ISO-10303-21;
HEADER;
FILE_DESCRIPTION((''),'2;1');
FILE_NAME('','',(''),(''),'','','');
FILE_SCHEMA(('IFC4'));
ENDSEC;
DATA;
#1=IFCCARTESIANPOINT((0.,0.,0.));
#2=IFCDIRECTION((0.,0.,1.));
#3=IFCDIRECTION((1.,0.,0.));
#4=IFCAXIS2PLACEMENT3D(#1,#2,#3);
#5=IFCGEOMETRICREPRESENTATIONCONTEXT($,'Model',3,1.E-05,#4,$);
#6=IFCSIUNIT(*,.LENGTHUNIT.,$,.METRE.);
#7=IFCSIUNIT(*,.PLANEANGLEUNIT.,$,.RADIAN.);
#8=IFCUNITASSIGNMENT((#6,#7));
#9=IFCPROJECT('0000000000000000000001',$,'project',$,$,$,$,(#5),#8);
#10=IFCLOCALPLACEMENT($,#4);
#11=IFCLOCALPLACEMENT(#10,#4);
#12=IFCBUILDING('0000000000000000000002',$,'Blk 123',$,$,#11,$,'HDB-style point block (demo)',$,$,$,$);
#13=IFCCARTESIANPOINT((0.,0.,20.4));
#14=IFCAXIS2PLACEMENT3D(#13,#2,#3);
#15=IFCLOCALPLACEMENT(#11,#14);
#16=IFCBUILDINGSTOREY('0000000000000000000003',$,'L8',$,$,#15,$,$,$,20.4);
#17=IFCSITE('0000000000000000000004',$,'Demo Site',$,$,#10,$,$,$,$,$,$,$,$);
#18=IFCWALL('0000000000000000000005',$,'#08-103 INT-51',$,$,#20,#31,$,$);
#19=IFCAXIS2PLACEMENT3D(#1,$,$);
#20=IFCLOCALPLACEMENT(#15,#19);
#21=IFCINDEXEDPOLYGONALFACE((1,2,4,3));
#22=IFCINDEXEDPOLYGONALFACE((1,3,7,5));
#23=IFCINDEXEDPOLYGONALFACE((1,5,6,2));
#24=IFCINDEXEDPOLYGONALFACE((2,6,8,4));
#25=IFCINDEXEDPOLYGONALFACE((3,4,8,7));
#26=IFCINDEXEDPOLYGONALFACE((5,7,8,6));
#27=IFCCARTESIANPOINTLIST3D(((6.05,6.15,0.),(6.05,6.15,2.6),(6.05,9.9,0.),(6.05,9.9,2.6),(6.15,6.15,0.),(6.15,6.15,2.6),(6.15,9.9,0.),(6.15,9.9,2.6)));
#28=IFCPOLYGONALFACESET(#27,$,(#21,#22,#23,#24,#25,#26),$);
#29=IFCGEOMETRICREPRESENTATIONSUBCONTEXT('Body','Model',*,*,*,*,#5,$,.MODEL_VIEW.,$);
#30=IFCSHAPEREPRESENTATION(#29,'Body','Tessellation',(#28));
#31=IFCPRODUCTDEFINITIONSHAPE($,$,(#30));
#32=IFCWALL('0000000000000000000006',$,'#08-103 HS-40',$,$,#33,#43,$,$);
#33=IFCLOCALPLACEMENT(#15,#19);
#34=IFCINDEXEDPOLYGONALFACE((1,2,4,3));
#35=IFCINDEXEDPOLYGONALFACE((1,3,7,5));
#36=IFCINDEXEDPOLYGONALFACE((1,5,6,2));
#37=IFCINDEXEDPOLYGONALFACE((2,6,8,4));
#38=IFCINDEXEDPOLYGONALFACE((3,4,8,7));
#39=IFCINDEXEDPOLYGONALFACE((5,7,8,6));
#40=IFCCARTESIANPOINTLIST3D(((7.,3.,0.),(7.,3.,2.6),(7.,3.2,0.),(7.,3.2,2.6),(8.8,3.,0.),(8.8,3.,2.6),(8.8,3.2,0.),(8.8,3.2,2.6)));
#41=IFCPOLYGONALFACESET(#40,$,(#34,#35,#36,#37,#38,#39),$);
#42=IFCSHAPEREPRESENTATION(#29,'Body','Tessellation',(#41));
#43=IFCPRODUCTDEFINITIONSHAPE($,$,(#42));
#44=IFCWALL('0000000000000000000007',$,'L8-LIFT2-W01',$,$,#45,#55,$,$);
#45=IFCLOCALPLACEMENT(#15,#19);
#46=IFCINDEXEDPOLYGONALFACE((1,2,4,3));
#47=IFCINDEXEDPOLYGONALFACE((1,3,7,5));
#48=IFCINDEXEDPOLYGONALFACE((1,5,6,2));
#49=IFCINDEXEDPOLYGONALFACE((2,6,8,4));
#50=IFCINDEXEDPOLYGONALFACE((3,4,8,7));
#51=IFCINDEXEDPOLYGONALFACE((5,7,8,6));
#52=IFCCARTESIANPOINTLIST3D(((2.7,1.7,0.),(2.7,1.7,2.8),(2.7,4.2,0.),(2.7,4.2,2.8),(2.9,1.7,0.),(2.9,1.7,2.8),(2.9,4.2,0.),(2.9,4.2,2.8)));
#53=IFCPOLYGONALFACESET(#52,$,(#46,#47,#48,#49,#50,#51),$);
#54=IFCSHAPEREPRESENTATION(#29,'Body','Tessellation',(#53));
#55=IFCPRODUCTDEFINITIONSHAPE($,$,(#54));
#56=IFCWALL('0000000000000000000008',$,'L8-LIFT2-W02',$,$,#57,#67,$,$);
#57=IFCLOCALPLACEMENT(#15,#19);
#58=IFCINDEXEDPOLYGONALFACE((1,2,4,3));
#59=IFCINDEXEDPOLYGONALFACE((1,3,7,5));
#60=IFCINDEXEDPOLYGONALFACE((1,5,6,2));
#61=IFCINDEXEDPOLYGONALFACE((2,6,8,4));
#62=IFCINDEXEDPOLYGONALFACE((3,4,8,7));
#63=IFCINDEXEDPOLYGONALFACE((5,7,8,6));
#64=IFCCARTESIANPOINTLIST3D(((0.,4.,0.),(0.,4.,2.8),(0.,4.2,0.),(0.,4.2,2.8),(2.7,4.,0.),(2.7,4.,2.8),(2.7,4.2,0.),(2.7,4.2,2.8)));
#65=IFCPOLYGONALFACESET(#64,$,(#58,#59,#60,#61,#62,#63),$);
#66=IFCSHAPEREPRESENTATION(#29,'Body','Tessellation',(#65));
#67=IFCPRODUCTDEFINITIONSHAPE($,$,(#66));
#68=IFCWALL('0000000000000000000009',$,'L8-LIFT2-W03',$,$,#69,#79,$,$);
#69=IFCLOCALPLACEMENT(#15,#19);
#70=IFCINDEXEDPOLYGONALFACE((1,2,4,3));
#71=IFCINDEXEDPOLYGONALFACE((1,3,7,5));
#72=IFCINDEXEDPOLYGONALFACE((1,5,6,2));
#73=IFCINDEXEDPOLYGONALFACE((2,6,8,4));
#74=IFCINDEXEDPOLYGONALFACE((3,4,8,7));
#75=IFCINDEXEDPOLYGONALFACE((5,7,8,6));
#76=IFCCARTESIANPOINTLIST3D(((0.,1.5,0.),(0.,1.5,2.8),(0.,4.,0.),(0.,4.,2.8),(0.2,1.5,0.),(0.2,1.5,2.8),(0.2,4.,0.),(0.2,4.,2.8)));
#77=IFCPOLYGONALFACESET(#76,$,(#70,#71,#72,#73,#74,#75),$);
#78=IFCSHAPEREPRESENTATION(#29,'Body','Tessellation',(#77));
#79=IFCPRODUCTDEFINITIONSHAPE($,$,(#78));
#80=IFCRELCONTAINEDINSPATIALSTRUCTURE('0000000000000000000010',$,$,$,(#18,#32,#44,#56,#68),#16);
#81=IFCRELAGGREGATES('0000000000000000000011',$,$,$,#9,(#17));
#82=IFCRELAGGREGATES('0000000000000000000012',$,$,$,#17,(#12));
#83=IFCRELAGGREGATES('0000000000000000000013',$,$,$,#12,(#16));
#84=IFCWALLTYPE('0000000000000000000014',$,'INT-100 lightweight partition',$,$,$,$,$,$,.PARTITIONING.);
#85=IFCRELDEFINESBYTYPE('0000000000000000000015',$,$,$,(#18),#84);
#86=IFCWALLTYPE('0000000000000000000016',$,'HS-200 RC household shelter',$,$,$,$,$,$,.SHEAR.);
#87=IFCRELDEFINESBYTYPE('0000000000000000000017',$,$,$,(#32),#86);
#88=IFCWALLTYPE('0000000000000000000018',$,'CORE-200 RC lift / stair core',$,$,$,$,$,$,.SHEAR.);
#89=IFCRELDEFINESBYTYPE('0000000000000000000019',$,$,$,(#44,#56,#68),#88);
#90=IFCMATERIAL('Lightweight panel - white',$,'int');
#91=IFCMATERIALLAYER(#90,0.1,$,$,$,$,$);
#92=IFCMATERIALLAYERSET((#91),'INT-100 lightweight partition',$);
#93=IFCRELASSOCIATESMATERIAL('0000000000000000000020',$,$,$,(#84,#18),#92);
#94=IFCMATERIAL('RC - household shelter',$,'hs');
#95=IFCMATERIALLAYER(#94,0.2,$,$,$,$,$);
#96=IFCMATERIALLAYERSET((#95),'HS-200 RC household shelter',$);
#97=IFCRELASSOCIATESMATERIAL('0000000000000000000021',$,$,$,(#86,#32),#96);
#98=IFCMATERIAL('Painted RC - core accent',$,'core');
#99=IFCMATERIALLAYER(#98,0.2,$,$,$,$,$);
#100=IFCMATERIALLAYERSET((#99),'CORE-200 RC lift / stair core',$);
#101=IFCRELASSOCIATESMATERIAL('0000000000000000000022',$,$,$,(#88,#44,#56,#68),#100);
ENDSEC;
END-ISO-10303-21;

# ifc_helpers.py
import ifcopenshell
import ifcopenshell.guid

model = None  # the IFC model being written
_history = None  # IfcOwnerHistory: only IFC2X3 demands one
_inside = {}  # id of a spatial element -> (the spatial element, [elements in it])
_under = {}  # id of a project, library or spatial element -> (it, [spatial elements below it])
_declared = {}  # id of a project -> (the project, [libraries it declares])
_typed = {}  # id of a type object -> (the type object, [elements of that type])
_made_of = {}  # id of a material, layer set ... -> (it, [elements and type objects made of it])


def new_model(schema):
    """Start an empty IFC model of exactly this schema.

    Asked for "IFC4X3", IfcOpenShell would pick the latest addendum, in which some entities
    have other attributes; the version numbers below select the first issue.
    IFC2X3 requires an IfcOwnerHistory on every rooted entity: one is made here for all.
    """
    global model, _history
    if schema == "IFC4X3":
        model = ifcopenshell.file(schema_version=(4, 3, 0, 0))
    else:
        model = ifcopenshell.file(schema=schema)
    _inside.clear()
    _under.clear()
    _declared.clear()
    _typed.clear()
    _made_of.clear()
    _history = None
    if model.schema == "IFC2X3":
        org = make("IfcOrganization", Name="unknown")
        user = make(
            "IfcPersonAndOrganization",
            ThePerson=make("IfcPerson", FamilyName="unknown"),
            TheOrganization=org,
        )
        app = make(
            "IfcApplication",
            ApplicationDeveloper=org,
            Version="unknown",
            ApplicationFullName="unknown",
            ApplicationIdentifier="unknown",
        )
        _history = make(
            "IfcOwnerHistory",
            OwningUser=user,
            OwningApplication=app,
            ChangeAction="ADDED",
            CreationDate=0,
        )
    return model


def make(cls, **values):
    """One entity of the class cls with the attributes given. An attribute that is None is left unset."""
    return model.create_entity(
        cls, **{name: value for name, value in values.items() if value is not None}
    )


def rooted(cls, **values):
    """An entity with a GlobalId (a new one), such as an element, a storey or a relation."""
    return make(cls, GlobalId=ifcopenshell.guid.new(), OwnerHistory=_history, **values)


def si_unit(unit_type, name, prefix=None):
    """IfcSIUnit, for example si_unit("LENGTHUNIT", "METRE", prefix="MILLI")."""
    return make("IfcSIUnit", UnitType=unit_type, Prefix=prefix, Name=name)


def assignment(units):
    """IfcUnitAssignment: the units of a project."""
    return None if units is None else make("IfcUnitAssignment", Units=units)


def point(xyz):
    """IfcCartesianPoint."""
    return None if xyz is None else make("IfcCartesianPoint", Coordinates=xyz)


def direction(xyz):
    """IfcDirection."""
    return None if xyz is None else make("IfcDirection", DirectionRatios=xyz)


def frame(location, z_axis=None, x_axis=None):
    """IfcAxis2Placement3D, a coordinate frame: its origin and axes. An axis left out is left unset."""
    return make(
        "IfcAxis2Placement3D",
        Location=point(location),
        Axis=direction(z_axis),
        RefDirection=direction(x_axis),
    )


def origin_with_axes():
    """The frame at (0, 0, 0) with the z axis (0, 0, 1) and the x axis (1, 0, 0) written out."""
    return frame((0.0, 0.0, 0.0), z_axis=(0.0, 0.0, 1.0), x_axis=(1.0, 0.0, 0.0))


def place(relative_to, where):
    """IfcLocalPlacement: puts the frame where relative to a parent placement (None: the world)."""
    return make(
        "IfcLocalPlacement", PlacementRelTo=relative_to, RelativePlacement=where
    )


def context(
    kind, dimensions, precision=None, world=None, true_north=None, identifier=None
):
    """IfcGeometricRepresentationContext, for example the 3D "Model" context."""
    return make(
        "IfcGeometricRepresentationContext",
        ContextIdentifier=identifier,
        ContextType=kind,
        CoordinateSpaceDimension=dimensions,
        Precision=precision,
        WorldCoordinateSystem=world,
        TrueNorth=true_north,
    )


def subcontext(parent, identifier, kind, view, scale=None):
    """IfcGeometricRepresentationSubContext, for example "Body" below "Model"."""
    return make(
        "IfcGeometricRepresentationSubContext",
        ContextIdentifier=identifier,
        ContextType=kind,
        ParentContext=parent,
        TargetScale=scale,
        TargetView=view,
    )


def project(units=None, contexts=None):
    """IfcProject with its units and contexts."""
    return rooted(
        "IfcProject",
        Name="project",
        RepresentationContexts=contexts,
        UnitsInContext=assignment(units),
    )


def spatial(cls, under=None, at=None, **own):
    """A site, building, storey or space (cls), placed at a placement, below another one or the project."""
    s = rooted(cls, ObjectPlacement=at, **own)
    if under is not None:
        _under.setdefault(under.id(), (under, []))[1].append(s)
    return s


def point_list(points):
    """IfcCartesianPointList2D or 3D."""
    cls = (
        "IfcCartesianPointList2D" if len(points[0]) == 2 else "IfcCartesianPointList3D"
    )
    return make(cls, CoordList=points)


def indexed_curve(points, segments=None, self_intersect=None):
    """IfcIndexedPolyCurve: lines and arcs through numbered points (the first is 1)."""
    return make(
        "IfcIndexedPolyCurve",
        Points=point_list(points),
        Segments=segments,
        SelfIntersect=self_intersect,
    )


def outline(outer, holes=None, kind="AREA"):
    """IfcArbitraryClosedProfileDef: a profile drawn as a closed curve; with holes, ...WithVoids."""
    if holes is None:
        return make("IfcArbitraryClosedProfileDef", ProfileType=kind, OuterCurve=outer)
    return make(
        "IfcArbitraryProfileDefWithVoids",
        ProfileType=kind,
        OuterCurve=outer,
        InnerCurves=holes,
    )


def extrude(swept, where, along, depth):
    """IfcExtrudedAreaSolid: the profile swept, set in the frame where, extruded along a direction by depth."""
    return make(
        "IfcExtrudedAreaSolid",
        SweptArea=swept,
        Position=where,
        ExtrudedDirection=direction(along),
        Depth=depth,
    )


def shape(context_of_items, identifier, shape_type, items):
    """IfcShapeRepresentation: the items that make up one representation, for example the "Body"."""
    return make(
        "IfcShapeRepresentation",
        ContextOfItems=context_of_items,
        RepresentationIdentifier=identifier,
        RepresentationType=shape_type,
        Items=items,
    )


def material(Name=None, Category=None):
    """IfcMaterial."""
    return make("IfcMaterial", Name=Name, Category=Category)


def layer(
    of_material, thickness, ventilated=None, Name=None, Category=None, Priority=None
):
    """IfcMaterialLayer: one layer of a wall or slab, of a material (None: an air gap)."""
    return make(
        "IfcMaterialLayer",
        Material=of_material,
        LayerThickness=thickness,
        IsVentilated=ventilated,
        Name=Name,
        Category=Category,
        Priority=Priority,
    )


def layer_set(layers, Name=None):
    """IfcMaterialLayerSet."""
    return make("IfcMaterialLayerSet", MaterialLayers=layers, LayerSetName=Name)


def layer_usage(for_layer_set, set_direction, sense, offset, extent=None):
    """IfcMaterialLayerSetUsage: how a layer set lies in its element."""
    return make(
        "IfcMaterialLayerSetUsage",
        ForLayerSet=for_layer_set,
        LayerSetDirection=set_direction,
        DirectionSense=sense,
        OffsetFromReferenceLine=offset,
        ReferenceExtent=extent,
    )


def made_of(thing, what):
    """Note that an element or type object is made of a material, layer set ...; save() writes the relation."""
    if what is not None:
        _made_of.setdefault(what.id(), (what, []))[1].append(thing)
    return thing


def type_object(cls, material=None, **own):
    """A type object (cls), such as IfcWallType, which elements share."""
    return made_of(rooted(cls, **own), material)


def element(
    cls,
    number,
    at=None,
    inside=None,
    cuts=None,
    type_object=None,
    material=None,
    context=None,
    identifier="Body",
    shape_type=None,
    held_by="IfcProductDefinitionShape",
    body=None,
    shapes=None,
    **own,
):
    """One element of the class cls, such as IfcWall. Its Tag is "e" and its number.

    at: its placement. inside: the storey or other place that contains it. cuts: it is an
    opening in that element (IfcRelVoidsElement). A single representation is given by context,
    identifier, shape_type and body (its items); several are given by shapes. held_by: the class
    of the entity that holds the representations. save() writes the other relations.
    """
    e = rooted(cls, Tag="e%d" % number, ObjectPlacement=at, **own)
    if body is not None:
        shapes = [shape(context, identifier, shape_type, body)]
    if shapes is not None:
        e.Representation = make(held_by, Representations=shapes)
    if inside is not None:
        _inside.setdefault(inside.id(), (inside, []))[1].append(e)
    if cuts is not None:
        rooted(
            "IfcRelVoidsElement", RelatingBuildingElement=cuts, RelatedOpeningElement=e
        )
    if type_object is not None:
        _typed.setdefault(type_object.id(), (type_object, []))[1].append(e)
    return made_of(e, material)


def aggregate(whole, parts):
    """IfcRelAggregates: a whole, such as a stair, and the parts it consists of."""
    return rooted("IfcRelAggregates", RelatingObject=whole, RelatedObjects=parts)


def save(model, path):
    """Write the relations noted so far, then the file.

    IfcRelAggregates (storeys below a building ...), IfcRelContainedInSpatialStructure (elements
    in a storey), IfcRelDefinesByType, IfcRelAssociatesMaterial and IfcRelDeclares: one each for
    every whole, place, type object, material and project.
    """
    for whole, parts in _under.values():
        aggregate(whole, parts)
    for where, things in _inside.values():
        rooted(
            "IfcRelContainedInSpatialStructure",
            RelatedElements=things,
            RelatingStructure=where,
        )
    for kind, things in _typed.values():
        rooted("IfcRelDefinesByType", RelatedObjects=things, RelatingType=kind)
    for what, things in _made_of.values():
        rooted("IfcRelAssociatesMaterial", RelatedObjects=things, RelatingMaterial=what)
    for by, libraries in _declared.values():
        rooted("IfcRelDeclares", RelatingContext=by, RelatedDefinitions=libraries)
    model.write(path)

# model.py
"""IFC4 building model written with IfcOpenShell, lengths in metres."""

from ifc_helpers import new_model, si_unit, frame, origin_with_axes, place, context, subcontext, project, spatial, indexed_curve, outline, extrude, material, layer, layer_set, layer_usage, type_object, element, save


model = new_model("IFC4")

# Units and contexts
model_context = context("Model", 3, precision=1e-05, world=origin_with_axes())
body_context = subcontext(model_context, "Body", "Model", "MODEL_VIEW")
ifc_project = project(units=[si_unit("LENGTHUNIT", "METRE"), si_unit("PLANEANGLEUNIT", "RADIAN")], contexts=[model_context])

# Site, building, storey
site_placement = place(None, origin_with_axes())
site = spatial("IfcSite", under=ifc_project, at=site_placement, Name="Demo Site")
building_placement = place(site_placement, origin_with_axes())
building = spatial("IfcBuilding", under=site, at=building_placement, Name="Blk 123", LongName="HDB-style point block (demo)")
storey_placement = place(building_placement, frame((0.0, 0.0, 20.4), z_axis=(0.0, 0.0, 1.0), x_axis=(1.0, 0.0, 0.0)))
storey = spatial("IfcBuildingStorey", under=building, at=storey_placement, Name="L8", Elevation=20.4)

# Shared definitions
ifc_material_1 = material(Name="Lightweight panel - white", Category="int")
ifc_layer_1 = layer(ifc_material_1, 0.1)
ifc_layer_set_1 = layer_set([ifc_layer_1], Name="INT-100 lightweight partition")
ifc_layer_usage_1 = layer_usage(ifc_layer_set_1, "AXIS2", "POSITIVE", -0.05)
wall_type_1 = type_object("IfcWallType", Name="INT-100 lightweight partition", PredefinedType="PARTITIONING", material=ifc_layer_set_1)

# Walls
wall_1_placement = place(storey_placement, frame((6.1, 6.15, 0.0), z_axis=(0.0, 0.0, 1.0), x_axis=(0.0, 1.0, 0.0)))
element("IfcWall", 1, at=wall_1_placement, inside=storey, type_object=wall_type_1, material=ifc_layer_usage_1, Name="#08-103 INT-51", context=body_context, shape_type="SweptSolid", body=[
    extrude(outline(indexed_curve([(0.0, 0.0), (0.0, 0.1), (3.75, 0.1), (3.75, 0.0), (0.0, 0.0)], self_intersect=False)), frame((0.0, -0.05, 0.0), z_axis=(0.0, 0.0, 1.0), x_axis=(1.0, 0.0, 0.0)), (0.0, 0.0, 1.0), 2.6),
])
ifc_material_2 = material(Name="RC - household shelter", Category="hs")
ifc_layer_2 = layer(ifc_material_2, 0.2)
ifc_layer_set_2 = layer_set([ifc_layer_2], Name="HS-200 RC household shelter")
ifc_layer_usage_2 = layer_usage(ifc_layer_set_2, "AXIS2", "POSITIVE", -0.1)
wall_type_2 = type_object("IfcWallType", Name="HS-200 RC household shelter", PredefinedType="SHEAR", material=ifc_layer_set_2)
wall_2_placement = place(storey_placement, frame((7.0, 3.1, 0.0), z_axis=(0.0, 0.0, 1.0), x_axis=(1.0, 0.0, 0.0)))
element("IfcWall", 2, at=wall_2_placement, inside=storey, type_object=wall_type_2, material=ifc_layer_usage_2, Name="#08-103 HS-40", context=body_context, shape_type="SweptSolid", body=[
    extrude(outline(indexed_curve([(0.0, 0.0), (0.0, 0.2), (1.8, 0.2), (1.8, 0.0), (0.0, 0.0)], self_intersect=False)), frame((0.0, -0.1, 0.0), z_axis=(0.0, 0.0, 1.0), x_axis=(1.0, 0.0, 0.0)), (0.0, 0.0, 1.0), 2.6),
])
ifc_material_3 = material(Name="Painted RC - core accent", Category="core")
ifc_layer_3 = layer(ifc_material_3, 0.2)
ifc_layer_set_3 = layer_set([ifc_layer_3], Name="CORE-200 RC lift / stair core")
ifc_layer_usage_3 = layer_usage(ifc_layer_set_3, "AXIS2", "POSITIVE", 0.0)
wall_type_3 = type_object("IfcWallType", Name="CORE-200 RC lift / stair core", PredefinedType="SHEAR", material=ifc_layer_set_3)
wall_3_placement = place(storey_placement, frame((2.9, 1.7, 0.0), z_axis=(0.0, 0.0, 1.0), x_axis=(0.0, 1.0, 0.0)))
element("IfcWall", 3, at=wall_3_placement, inside=storey, type_object=wall_type_3, material=ifc_layer_usage_3, Name="L8-LIFT2-W01", context=body_context, shape_type="SweptSolid", body=[
    extrude(outline(indexed_curve([(0.0, 0.0), (0.0, 0.2), (2.5, 0.2), (2.5, 0.0), (0.0, 0.0)], self_intersect=False)), origin_with_axes(), (0.0, 0.0, 1.0), 2.8),
])
wall_4_placement = place(storey_placement, frame((2.7, 4.2, 0.0), z_axis=(0.0, 0.0, 1.0), x_axis=(-1.0, 0.0, 0.0)))
element("IfcWall", 4, at=wall_4_placement, inside=storey, type_object=wall_type_3, material=ifc_layer_usage_3, Name="L8-LIFT2-W02", context=body_context, shape_type="SweptSolid", body=[
    extrude(outline(indexed_curve([(0.0, 0.0), (0.0, 0.2), (2.7, 0.2), (2.7, 0.0), (0.0, 0.0)], self_intersect=False)), origin_with_axes(), (0.0, 0.0, 1.0), 2.8),
])
wall_5_placement = place(storey_placement, frame((0.0, 4.0, 0.0), z_axis=(0.0, 0.0, 1.0), x_axis=(0.0, -1.0, 0.0)))
element("IfcWall", 5, at=wall_5_placement, inside=storey, type_object=wall_type_3, material=ifc_layer_usage_3, Name="L8-LIFT2-W03", context=body_context, shape_type="SweptSolid", body=[
    extrude(outline(indexed_curve([(0.0, 0.0), (0.0, 0.2), (2.5, 0.2), (2.5, 0.0), (0.0, 0.0)], self_intersect=False)), origin_with_axes(), (0.0, 0.0, 1.0), 2.8),
])

save(model, "model.ifc")
